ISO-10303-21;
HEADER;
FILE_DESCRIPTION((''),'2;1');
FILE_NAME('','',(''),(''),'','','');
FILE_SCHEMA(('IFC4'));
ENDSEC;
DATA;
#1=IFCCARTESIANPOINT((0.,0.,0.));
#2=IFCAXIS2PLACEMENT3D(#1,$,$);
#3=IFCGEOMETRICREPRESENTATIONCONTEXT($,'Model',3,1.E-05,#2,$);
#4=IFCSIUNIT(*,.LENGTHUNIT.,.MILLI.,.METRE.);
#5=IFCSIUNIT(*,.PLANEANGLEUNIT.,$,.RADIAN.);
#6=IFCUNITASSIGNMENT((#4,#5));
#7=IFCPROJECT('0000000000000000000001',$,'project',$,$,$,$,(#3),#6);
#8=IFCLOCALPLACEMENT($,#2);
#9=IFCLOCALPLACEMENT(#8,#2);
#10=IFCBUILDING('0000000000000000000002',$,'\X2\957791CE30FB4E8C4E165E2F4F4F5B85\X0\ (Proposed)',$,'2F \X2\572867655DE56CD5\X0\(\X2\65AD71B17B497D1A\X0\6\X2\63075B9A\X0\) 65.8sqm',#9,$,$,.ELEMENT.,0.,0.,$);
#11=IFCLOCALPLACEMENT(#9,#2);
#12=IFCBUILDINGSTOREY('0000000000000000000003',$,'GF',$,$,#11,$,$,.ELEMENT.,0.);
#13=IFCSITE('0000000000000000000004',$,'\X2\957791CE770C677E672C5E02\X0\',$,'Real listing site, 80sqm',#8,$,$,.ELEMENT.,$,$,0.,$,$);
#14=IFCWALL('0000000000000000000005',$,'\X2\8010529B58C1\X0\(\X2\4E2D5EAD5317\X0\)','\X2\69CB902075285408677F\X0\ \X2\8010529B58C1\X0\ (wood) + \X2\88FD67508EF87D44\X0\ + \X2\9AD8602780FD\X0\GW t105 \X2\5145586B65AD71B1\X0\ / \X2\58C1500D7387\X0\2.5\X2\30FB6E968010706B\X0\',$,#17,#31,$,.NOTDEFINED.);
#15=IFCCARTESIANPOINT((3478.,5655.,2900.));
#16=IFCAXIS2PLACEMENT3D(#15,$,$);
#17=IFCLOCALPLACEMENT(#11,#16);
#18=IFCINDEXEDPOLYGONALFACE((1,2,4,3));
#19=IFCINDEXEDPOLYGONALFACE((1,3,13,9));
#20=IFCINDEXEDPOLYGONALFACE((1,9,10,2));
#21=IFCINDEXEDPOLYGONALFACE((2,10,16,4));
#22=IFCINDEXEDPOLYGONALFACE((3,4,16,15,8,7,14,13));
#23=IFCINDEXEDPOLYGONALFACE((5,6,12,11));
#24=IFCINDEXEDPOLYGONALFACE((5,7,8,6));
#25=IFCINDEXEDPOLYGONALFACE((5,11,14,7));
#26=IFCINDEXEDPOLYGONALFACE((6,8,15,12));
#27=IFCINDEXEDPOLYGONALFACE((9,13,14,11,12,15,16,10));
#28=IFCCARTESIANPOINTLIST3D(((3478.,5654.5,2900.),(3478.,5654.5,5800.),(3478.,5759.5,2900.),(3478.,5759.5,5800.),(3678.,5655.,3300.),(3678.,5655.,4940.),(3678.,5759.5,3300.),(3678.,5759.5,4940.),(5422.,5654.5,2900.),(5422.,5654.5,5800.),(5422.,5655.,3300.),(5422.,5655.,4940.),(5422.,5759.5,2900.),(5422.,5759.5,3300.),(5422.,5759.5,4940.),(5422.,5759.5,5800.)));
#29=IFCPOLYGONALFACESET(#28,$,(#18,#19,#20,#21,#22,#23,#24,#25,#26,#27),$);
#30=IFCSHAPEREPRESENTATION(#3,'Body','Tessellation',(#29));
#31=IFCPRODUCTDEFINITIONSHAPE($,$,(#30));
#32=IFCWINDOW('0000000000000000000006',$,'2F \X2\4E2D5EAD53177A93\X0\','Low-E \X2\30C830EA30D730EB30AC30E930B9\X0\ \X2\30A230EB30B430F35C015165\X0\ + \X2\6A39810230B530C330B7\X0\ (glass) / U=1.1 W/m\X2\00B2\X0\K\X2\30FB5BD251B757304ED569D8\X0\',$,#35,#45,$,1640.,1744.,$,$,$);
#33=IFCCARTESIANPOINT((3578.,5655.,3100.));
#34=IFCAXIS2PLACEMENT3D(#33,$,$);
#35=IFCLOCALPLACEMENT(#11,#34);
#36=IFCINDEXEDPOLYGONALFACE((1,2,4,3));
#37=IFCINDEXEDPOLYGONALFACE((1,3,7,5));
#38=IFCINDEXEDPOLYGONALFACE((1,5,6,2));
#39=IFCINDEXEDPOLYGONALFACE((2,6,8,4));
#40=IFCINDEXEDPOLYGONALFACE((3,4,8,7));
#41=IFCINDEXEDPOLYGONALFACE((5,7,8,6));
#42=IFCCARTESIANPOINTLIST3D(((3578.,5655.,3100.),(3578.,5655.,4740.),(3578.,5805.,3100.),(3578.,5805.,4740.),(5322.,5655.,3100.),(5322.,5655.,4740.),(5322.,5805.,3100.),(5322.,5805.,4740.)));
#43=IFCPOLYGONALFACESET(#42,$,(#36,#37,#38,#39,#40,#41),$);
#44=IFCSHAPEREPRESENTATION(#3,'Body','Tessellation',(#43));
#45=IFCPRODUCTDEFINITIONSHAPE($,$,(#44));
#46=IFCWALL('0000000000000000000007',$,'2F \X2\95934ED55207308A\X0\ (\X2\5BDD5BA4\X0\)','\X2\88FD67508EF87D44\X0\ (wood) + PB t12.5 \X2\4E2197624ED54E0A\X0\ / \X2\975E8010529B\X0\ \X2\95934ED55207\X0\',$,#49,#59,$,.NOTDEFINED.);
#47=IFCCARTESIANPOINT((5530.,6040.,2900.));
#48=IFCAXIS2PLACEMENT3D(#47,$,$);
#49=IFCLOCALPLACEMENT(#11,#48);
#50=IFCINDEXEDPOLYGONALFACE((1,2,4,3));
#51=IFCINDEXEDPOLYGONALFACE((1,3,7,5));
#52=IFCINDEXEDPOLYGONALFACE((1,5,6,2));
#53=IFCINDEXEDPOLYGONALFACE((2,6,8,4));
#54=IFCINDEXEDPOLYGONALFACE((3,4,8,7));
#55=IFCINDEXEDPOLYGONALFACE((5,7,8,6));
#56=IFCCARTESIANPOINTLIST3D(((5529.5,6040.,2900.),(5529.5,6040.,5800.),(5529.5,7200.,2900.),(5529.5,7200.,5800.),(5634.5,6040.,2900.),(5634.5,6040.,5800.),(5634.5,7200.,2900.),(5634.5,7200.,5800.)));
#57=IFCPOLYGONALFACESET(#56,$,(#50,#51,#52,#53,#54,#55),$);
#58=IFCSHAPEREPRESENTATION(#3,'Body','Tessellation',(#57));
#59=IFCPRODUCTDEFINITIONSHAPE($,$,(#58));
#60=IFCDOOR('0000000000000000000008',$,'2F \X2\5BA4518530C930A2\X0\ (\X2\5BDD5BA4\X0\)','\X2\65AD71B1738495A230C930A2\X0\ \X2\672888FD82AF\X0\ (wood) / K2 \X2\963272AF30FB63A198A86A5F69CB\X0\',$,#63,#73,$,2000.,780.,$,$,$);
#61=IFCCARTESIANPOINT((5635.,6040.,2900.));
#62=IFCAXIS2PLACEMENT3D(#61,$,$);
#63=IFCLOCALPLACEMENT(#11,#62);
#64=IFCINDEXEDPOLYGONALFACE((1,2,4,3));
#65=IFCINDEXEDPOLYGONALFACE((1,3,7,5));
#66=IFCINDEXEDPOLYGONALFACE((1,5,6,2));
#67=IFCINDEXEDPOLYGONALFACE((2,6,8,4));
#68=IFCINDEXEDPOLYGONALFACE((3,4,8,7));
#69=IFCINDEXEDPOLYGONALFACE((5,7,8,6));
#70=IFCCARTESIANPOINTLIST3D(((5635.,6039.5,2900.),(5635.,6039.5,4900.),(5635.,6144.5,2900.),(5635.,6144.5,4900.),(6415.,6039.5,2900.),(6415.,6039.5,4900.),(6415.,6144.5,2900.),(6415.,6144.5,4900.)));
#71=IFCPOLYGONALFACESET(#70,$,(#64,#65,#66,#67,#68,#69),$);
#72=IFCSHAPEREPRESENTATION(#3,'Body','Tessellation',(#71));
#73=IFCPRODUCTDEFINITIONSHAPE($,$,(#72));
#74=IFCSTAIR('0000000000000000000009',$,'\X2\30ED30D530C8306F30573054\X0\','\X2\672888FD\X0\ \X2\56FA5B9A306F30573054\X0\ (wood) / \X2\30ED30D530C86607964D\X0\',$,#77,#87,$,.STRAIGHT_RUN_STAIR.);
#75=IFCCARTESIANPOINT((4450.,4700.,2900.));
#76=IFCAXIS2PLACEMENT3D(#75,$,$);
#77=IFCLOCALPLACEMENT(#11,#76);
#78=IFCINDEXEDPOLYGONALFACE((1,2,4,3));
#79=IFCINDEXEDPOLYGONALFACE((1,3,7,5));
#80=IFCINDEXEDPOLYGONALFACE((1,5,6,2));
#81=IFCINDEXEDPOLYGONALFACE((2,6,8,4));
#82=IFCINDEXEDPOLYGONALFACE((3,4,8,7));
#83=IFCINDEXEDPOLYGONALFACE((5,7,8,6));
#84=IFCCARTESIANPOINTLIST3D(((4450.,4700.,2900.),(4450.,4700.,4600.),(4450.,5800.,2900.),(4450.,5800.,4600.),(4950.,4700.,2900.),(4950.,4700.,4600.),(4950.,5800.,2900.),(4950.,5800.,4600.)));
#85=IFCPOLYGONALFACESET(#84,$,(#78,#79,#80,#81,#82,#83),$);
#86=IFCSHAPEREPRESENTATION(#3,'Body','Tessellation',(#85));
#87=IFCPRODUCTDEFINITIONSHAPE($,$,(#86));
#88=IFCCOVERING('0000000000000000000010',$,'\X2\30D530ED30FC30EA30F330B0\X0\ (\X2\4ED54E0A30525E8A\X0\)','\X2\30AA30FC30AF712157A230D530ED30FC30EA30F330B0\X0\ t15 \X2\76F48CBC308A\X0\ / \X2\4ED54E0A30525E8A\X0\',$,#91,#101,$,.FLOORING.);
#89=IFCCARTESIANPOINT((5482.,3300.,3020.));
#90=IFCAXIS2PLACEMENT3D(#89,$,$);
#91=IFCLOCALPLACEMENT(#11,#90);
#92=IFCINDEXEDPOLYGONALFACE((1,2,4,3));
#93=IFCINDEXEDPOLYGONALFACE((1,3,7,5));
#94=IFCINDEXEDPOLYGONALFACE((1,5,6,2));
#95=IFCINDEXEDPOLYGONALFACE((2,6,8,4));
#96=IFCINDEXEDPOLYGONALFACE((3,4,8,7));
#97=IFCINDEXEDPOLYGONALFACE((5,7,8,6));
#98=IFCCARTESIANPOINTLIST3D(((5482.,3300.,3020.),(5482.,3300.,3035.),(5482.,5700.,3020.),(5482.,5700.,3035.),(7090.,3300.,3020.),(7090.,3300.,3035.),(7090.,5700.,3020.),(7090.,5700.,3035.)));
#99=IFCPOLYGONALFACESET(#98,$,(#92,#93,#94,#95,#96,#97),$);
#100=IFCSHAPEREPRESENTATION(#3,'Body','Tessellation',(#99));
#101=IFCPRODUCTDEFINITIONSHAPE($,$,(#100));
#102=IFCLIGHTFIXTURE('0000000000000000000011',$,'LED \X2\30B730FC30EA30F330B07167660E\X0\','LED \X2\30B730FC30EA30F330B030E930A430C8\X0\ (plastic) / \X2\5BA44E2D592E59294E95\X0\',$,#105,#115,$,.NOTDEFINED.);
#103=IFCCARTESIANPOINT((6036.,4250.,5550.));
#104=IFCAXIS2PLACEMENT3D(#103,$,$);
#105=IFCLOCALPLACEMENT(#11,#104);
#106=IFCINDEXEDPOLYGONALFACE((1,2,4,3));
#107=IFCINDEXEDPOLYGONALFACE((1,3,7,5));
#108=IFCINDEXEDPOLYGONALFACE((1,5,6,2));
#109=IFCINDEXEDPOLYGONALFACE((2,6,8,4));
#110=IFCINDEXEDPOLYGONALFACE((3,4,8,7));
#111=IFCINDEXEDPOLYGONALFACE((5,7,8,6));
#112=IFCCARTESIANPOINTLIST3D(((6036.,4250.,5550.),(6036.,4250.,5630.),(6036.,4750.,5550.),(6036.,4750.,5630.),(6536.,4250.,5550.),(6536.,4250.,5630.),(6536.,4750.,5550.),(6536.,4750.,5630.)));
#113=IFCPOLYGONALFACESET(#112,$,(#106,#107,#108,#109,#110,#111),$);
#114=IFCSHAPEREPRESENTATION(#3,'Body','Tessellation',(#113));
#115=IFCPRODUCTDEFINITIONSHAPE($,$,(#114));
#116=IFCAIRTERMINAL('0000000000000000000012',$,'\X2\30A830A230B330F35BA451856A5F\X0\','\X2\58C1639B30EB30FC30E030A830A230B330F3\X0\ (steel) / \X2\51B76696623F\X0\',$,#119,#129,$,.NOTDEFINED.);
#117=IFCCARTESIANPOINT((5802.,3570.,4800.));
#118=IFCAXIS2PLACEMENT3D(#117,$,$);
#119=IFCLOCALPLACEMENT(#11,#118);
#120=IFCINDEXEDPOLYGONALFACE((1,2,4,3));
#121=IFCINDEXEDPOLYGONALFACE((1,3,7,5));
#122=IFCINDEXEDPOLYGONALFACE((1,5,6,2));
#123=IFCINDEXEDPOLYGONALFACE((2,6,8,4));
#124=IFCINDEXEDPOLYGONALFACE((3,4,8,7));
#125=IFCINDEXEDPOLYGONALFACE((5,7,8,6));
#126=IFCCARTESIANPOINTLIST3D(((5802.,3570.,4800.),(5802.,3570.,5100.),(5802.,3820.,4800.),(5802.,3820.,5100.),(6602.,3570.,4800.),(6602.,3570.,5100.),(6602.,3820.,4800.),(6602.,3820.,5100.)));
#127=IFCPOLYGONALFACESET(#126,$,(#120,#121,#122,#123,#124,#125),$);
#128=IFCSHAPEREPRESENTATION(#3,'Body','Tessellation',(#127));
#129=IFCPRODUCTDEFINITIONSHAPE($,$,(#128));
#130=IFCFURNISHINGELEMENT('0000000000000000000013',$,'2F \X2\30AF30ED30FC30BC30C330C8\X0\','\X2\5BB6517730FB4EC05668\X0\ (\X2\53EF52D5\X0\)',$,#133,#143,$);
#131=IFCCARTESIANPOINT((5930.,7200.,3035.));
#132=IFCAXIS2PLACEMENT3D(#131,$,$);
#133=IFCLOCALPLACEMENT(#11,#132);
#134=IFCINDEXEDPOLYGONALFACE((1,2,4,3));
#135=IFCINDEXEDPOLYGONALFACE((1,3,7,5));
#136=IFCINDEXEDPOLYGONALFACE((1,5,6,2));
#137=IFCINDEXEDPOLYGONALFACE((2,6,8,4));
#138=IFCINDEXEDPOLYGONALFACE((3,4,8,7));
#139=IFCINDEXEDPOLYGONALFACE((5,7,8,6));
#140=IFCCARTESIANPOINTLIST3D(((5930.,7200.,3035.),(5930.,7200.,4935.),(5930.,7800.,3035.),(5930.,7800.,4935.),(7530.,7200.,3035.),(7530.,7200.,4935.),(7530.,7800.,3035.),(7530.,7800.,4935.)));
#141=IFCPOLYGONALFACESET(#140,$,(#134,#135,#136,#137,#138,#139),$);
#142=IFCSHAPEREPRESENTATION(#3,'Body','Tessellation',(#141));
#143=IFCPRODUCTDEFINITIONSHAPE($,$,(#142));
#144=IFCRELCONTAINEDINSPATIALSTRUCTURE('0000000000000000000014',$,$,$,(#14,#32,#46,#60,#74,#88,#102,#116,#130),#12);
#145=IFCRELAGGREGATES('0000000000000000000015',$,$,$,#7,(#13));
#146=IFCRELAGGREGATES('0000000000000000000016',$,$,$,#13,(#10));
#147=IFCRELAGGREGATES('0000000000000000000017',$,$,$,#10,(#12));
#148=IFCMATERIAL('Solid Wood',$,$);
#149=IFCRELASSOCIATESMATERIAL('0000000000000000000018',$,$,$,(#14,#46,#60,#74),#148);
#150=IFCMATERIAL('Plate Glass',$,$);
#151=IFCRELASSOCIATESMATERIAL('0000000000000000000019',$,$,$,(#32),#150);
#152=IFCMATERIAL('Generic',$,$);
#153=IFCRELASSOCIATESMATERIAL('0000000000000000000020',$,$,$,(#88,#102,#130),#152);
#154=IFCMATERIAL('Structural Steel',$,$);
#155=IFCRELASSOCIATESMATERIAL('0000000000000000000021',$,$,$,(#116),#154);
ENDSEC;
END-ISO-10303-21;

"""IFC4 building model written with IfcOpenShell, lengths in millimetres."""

from ifc_helpers import new_model, si_unit, frame, frame_2d, origin, place, context, project, spatial, rectangle, extrude, material, element, fill, save


model = new_model("IFC4")

# Units and contexts
model_context = context("Model", 3, precision=1e-05, world=origin())
ifc_project = project(units=[si_unit("LENGTHUNIT", "METRE", prefix="MILLI"), si_unit("PLANEANGLEUNIT", "RADIAN")], contexts=[model_context])

# Site, building, storey
site_placement = place(None, origin())
site = spatial("IfcSite", under=ifc_project, at=site_placement, Name="長野県松本市", ObjectType="Real listing site, 80sqm", CompositionType="ELEMENT", RefElevation=0.0)
building_placement = place(site_placement, origin())
building = spatial("IfcBuilding", under=site, at=building_placement, Name="長野・二世帯住宅 (Proposed)", ObjectType="2F 在来工法(断熱等級6指定) 65.8sqm", CompositionType="ELEMENT", ElevationOfRefHeight=0.0, ElevationOfTerrain=0.0)
storey_placement = place(building_placement, origin())
storey = spatial("IfcBuildingStorey", under=building, at=storey_placement, Name="GF", CompositionType="ELEMENT", Elevation=0.0)

# Shared definitions
ifc_material_1 = material(Name="Solid Wood")

# Wall, opening, window
wall_1_placement = place(storey_placement, frame((3478.0, 5655.0, 2900.0)))
wall_1 = element("IfcWall", 1, at=wall_1_placement, inside=storey, material=ifc_material_1, Name="耐力壁(中庭北)", Description="構造用合板 耐力壁 (wood) + 製材軸組 + 高性能GW t105 充填断熱 / 壁倍率2.5・準耐火", PredefinedType="NOTDEFINED", context=model_context, shape_type="SweptSolid", body=[
    extrude(rectangle(XDim=1944.0, YDim=105.0, at=frame_2d((972.0, 52.0))), frame((3478.0, 5655.0, 2900.0)), (0.0, 0.0, 1.0), 2900.0),
])
opening_placement = place(storey_placement, frame((3578.0, 5655.0, 3100.0)))
opening = element("IfcOpeningElement", 2, at=opening_placement, cuts=wall_1, PredefinedType="NOTDEFINED", context=model_context, shape_type="SweptSolid", body=[
    extrude(rectangle(XDim=1744.0, YDim=150.0, at=frame_2d((872.0, 75.0))), frame((3578.0, 5655.0, 3100.0)), (0.0, 0.0, 1.0), 1640.0),
])
ifc_material_2 = material(Name="Plate Glass")
window_placement = place(storey_placement, frame((3578.0, 5655.0, 3100.0)))
window = element("IfcWindow", 3, at=window_placement, inside=storey, material=ifc_material_2, Name="2F 中庭北窓", Description="Low-E トリプルガラス アルゴン封入 + 樹脂サッシ (glass) / U=1.1 W/m²K・寒冷地仕様", OverallHeight=1640.0, OverallWidth=1744.0, context=model_context, shape_type="SweptSolid", body=[
    extrude(rectangle(XDim=1744.0, YDim=150.0, at=frame_2d((872.0, 75.0))), frame((3578.0, 5655.0, 3100.0)), (0.0, 0.0, 1.0), 1640.0),
])
fill(opening, window)

# Wall
wall_2_placement = place(storey_placement, frame((5530.0, 6040.0, 2900.0)))
element("IfcWall", 4, at=wall_2_placement, inside=storey, material=ifc_material_1, Name="2F 間仕切り (寝室)", Description="製材軸組 (wood) + PB t12.5 両面仕上 / 非耐力 間仕切", PredefinedType="NOTDEFINED", context=model_context, shape_type="SweptSolid", body=[
    extrude(rectangle(XDim=105.0, YDim=1160.0, at=frame_2d((52.0, 580.0))), frame((5530.0, 6040.0, 2900.0)), (0.0, 0.0, 1.0), 2900.0),
])

# Door
door_placement = place(storey_placement, frame((5635.0, 6040.0, 2900.0)))
element("IfcDoor", 5, at=door_placement, inside=storey, material=ifc_material_1, Name="2F 室内ドア (寝室)", Description="断熱玄関ドア 木製芯 (wood) / K2 防犯・採風機構", OverallHeight=2000.0, OverallWidth=780.0, context=model_context, shape_type="SweptSolid", body=[
    extrude(rectangle(XDim=780.0, YDim=105.0, at=frame_2d((390.0, 52.0))), frame((5635.0, 6040.0, 2900.0)), (0.0, 0.0, 1.0), 2000.0),
])

# Stair
stair_placement = place(storey_placement, frame((4450.0, 4700.0, 2900.0)))
element("IfcStair", 6, at=stair_placement, inside=storey, material=ifc_material_1, Name="ロフトはしご", Description="木製 固定はしご (wood) / ロフト昇降", PredefinedType="STRAIGHT_RUN_STAIR", context=model_context, shape_type="SweptSolid", body=[
    extrude(rectangle(XDim=500.0, YDim=1100.0, at=frame_2d((250.0, 550.0))), frame((4450.0, 4700.0, 2900.0)), (0.0, 0.0, 1.0), 1700.0),
])

# Covering
ifc_material_3 = material(Name="Generic")
covering_placement = place(storey_placement, frame((5482.0, 3300.0, 3020.0)))
element("IfcCovering", 7, at=covering_placement, inside=storey, material=ifc_material_3, Name="フローリング (仕上げ床)", Description="オーク無垢フローリング t15 直貼り / 仕上げ床", PredefinedType="FLOORING", context=model_context, shape_type="SweptSolid", body=[
    extrude(rectangle(XDim=1608.0, YDim=2400.0, at=frame_2d((804.0, 1200.0))), frame((5482.0, 3300.0, 3020.0)), (0.0, 0.0, 1.0), 15.0),
])

# Light fixture
light_fixture_placement = place(storey_placement, frame((6036.0, 4250.0, 5550.0)))
element("IfcLightFixture", 8, at=light_fixture_placement, inside=storey, material=ifc_material_3, Name="LED シーリング照明", Description="LED シーリングライト (plastic) / 室中央天井", PredefinedType="NOTDEFINED", context=model_context, shape_type="SweptSolid", body=[
    extrude(rectangle(XDim=500.0, YDim=500.0, at=frame_2d((250.0, 250.0))), frame((6036.0, 4250.0, 5550.0)), (0.0, 0.0, 1.0), 80.0),
])

# Air terminal
ifc_material_4 = material(Name="Structural Steel")
air_terminal_placement = place(storey_placement, frame((5802.0, 3570.0, 4800.0)))
element("IfcAirTerminal", 9, at=air_terminal_placement, inside=storey, material=ifc_material_4, Name="エアコン室内機", Description="壁掛ルームエアコン (steel) / 冷暖房", PredefinedType="NOTDEFINED", context=model_context, shape_type="SweptSolid", body=[
    extrude(rectangle(XDim=800.0, YDim=250.0, at=frame_2d((400.0, 125.0))), frame((5802.0, 3570.0, 4800.0)), (0.0, 0.0, 1.0), 300.0),
])

# Furnishing element
furnishing_placement = place(storey_placement, frame((5930.0, 7200.0, 3035.0)))
element("IfcFurnishingElement", 10, at=furnishing_placement, inside=storey, material=ifc_material_3, Name="2F クローゼット", Description="家具・什器 (可動)", context=model_context, shape_type="SweptSolid", body=[
    extrude(rectangle(XDim=1600.0, YDim=600.0, at=frame_2d((800.0, 300.0))), frame((5930.0, 7200.0, 3035.0)), (0.0, 0.0, 1.0), 1900.0),
])

save(model, "model.ifc")
